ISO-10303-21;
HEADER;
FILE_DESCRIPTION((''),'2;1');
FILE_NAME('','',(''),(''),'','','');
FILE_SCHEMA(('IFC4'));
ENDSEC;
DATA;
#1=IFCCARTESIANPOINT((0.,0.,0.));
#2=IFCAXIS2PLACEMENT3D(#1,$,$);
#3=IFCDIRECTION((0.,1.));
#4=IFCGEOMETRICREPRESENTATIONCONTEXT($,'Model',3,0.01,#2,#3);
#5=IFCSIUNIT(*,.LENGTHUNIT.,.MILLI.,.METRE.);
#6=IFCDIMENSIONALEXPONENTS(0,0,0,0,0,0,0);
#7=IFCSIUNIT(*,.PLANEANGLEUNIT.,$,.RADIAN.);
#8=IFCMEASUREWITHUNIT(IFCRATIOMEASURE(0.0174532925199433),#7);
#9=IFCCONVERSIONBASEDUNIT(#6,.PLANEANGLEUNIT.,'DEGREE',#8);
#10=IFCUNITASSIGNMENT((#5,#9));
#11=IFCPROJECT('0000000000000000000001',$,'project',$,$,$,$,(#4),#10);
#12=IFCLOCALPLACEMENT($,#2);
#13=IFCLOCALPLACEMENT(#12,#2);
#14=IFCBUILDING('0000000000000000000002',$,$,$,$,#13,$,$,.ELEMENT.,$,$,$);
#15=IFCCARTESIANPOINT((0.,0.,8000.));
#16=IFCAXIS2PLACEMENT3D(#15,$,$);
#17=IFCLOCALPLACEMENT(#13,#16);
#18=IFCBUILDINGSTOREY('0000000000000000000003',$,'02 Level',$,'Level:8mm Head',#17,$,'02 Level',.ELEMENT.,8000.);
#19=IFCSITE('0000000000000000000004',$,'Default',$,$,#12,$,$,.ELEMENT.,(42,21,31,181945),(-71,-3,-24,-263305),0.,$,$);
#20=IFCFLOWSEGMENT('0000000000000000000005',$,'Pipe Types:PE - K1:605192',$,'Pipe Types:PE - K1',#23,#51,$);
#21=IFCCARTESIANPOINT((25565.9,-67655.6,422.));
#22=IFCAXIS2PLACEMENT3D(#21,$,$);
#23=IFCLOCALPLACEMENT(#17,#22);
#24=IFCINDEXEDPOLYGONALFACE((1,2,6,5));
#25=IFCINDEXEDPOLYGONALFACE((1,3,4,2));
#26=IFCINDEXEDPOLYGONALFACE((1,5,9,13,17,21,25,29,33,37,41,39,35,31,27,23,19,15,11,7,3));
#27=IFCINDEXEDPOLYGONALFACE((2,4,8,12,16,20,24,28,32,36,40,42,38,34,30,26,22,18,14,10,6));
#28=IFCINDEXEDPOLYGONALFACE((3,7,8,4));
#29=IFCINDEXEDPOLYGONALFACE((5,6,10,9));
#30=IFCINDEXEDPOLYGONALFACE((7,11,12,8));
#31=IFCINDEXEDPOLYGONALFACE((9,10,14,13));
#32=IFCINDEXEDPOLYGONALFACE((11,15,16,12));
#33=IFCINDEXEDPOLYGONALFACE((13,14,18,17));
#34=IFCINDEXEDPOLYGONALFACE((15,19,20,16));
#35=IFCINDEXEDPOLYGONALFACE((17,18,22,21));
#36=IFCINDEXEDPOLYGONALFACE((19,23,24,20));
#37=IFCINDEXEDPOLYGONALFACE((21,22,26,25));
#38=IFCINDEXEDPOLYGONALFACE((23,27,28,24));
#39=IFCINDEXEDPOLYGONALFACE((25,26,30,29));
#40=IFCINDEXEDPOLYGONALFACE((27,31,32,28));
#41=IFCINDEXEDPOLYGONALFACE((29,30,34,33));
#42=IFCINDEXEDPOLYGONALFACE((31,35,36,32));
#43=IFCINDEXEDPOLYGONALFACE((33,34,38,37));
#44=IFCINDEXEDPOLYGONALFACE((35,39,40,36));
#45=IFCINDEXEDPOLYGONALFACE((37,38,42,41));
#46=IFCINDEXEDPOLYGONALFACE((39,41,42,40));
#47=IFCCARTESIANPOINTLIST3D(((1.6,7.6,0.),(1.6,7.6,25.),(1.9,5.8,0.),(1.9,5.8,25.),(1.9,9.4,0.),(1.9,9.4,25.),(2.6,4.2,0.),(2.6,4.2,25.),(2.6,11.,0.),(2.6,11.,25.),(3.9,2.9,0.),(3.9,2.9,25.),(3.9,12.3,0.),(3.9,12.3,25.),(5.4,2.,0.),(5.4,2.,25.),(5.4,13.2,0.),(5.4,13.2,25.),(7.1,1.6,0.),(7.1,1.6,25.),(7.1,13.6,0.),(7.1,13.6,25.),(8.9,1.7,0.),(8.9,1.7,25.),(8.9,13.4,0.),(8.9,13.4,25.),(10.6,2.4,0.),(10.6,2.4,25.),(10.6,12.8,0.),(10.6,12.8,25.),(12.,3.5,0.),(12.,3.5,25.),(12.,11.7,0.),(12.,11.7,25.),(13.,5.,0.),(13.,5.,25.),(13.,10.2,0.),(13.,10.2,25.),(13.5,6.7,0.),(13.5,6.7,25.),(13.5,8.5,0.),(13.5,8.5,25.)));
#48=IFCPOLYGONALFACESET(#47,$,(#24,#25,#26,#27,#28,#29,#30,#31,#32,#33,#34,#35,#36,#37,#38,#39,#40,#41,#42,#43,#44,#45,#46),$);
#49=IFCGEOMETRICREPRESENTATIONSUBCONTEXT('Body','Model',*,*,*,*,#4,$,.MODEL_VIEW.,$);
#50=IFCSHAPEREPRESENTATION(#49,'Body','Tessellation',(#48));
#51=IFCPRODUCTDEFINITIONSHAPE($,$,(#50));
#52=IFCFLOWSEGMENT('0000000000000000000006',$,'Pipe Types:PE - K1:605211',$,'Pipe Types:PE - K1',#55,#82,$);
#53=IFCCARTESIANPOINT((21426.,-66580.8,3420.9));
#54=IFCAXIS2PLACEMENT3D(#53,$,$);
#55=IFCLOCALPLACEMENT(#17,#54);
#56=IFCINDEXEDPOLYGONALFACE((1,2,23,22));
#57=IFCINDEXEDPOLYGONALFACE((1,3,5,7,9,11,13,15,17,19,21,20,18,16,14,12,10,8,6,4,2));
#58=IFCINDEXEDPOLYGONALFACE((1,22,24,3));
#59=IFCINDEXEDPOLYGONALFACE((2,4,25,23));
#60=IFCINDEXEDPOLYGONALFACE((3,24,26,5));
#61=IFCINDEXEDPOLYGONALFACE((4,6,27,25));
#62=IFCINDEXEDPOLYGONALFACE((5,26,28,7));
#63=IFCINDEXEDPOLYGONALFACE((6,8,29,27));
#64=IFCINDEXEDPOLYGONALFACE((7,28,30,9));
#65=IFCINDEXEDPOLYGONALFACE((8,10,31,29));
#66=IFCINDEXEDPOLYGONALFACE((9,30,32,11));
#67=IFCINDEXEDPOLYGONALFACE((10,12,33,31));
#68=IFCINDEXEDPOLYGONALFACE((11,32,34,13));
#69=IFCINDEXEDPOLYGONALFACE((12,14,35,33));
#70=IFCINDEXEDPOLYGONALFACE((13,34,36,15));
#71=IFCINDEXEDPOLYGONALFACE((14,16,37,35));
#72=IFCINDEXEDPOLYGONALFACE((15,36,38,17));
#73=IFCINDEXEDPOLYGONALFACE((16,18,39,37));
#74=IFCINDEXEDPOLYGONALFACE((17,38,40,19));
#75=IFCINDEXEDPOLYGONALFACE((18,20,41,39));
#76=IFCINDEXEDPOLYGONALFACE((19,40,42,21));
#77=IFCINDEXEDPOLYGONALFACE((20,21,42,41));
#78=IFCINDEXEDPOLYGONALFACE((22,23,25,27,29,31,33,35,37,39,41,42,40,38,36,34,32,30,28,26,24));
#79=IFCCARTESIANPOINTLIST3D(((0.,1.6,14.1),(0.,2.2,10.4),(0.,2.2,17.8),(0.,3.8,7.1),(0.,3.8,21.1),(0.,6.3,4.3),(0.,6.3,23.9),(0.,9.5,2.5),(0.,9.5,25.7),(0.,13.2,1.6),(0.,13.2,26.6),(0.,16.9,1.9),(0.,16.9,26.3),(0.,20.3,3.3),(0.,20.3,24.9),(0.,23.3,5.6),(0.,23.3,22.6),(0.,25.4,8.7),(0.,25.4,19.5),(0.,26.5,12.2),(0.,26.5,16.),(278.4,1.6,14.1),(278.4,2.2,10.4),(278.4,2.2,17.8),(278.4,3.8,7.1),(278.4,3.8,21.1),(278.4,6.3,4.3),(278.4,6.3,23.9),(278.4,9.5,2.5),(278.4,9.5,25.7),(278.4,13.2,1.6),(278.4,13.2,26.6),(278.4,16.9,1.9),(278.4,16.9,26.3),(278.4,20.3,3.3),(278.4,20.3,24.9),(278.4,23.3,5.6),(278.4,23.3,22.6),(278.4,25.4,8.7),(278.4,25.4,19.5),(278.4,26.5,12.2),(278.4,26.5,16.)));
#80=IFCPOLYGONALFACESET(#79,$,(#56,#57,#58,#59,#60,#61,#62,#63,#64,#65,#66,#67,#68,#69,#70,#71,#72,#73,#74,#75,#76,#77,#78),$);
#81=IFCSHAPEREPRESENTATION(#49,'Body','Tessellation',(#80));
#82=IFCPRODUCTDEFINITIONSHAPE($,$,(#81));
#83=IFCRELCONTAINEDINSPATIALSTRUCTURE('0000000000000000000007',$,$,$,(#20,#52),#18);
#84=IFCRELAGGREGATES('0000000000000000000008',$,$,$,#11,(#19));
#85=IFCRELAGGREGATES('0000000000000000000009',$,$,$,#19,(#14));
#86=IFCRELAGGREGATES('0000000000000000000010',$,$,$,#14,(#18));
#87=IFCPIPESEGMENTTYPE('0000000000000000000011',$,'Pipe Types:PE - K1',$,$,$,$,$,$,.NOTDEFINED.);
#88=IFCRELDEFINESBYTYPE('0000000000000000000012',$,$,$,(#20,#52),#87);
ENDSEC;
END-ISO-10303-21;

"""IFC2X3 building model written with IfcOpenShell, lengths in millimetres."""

from ifc_helpers import new_model, entity, si_unit, converted_unit, direction, frame, origin, origin_2d_with_axis, place, context, subcontext, project, spatial, circle, extrude, type_object, element, save


model = new_model("IFC2X3")

# Units and contexts
model_context = context("Model", 3, precision=0.01, world=origin(), true_north=direction((0.0, 1.0)))
body_context = subcontext(model_context, "Body", "Model", "MODEL_VIEW")
ifc_project = project(units=[si_unit("LENGTHUNIT", "METRE", prefix="MILLI"), converted_unit("PLANEANGLEUNIT", "DEGREE", entity("IfcRatioMeasure", 0.0174532925199433), si_unit("PLANEANGLEUNIT", "RADIAN"), dimensions=[0, 0, 0, 0, 0, 0, 0])], contexts=[model_context])

# Site, building, storey
site_placement = place(None, origin())
site = spatial("IfcSite", under=ifc_project, at=site_placement, Name="Default", CompositionType="ELEMENT", RefLatitude=(42, 21, 31, 181945), RefLongitude=(-71, -3, -24, -263305), RefElevation=0.0)
building_placement = place(site_placement, origin())
building = spatial("IfcBuilding", under=site, at=building_placement, CompositionType="ELEMENT")
storey_placement = place(building_placement, frame((0.0, 0.0, 8000.0)))
storey = spatial("IfcBuildingStorey", under=building, at=storey_placement, Name="02 Level", ObjectType="Level:8mm Head", LongName="02 Level", CompositionType="ELEMENT", Elevation=8000.0)

# Flow segments
pipe_segment_type = type_object("IfcPipeSegmentType", Name="Pipe Types:PE - K1", PredefinedType="NOTDEFINED")
flow_segment_1_placement = place(storey_placement, frame((25565.9, -67655.6, 422.0)))
element("IfcFlowSegment", 1, at=flow_segment_1_placement, inside=storey, type_object=pipe_segment_type, Name="Pipe Types:PE - K1:605192", ObjectType="Pipe Types:PE - K1", context=body_context, shape_type="SweptSolid", body=[
    extrude(circle(Radius=6.0, at=origin_2d_with_axis()), frame((7.6, 7.6, 0.0), z_axis=(0.0, 0.0, 1.0), x_axis=(-1.0, 0.0, 0.0)), (0.0, 0.0, 1.0), 25.0),
])
flow_segment_2_placement = place(storey_placement, frame((21426.0, -66580.8, 3420.9)))
element("IfcFlowSegment", 2, at=flow_segment_2_placement, inside=storey, type_object=pipe_segment_type, Name="Pipe Types:PE - K1:605211", ObjectType="Pipe Types:PE - K1", context=body_context, shape_type="SweptSolid", body=[
    extrude(circle(Radius=12.5, at=origin_2d_with_axis()), frame((0.0, 14.1, 14.1), z_axis=(1.0, 0.0, 0.0), x_axis=(0.0, -1.0, 0.0)), (0.0, 0.0, 1.0), 278.4),
])

save(model, "model.ifc")
